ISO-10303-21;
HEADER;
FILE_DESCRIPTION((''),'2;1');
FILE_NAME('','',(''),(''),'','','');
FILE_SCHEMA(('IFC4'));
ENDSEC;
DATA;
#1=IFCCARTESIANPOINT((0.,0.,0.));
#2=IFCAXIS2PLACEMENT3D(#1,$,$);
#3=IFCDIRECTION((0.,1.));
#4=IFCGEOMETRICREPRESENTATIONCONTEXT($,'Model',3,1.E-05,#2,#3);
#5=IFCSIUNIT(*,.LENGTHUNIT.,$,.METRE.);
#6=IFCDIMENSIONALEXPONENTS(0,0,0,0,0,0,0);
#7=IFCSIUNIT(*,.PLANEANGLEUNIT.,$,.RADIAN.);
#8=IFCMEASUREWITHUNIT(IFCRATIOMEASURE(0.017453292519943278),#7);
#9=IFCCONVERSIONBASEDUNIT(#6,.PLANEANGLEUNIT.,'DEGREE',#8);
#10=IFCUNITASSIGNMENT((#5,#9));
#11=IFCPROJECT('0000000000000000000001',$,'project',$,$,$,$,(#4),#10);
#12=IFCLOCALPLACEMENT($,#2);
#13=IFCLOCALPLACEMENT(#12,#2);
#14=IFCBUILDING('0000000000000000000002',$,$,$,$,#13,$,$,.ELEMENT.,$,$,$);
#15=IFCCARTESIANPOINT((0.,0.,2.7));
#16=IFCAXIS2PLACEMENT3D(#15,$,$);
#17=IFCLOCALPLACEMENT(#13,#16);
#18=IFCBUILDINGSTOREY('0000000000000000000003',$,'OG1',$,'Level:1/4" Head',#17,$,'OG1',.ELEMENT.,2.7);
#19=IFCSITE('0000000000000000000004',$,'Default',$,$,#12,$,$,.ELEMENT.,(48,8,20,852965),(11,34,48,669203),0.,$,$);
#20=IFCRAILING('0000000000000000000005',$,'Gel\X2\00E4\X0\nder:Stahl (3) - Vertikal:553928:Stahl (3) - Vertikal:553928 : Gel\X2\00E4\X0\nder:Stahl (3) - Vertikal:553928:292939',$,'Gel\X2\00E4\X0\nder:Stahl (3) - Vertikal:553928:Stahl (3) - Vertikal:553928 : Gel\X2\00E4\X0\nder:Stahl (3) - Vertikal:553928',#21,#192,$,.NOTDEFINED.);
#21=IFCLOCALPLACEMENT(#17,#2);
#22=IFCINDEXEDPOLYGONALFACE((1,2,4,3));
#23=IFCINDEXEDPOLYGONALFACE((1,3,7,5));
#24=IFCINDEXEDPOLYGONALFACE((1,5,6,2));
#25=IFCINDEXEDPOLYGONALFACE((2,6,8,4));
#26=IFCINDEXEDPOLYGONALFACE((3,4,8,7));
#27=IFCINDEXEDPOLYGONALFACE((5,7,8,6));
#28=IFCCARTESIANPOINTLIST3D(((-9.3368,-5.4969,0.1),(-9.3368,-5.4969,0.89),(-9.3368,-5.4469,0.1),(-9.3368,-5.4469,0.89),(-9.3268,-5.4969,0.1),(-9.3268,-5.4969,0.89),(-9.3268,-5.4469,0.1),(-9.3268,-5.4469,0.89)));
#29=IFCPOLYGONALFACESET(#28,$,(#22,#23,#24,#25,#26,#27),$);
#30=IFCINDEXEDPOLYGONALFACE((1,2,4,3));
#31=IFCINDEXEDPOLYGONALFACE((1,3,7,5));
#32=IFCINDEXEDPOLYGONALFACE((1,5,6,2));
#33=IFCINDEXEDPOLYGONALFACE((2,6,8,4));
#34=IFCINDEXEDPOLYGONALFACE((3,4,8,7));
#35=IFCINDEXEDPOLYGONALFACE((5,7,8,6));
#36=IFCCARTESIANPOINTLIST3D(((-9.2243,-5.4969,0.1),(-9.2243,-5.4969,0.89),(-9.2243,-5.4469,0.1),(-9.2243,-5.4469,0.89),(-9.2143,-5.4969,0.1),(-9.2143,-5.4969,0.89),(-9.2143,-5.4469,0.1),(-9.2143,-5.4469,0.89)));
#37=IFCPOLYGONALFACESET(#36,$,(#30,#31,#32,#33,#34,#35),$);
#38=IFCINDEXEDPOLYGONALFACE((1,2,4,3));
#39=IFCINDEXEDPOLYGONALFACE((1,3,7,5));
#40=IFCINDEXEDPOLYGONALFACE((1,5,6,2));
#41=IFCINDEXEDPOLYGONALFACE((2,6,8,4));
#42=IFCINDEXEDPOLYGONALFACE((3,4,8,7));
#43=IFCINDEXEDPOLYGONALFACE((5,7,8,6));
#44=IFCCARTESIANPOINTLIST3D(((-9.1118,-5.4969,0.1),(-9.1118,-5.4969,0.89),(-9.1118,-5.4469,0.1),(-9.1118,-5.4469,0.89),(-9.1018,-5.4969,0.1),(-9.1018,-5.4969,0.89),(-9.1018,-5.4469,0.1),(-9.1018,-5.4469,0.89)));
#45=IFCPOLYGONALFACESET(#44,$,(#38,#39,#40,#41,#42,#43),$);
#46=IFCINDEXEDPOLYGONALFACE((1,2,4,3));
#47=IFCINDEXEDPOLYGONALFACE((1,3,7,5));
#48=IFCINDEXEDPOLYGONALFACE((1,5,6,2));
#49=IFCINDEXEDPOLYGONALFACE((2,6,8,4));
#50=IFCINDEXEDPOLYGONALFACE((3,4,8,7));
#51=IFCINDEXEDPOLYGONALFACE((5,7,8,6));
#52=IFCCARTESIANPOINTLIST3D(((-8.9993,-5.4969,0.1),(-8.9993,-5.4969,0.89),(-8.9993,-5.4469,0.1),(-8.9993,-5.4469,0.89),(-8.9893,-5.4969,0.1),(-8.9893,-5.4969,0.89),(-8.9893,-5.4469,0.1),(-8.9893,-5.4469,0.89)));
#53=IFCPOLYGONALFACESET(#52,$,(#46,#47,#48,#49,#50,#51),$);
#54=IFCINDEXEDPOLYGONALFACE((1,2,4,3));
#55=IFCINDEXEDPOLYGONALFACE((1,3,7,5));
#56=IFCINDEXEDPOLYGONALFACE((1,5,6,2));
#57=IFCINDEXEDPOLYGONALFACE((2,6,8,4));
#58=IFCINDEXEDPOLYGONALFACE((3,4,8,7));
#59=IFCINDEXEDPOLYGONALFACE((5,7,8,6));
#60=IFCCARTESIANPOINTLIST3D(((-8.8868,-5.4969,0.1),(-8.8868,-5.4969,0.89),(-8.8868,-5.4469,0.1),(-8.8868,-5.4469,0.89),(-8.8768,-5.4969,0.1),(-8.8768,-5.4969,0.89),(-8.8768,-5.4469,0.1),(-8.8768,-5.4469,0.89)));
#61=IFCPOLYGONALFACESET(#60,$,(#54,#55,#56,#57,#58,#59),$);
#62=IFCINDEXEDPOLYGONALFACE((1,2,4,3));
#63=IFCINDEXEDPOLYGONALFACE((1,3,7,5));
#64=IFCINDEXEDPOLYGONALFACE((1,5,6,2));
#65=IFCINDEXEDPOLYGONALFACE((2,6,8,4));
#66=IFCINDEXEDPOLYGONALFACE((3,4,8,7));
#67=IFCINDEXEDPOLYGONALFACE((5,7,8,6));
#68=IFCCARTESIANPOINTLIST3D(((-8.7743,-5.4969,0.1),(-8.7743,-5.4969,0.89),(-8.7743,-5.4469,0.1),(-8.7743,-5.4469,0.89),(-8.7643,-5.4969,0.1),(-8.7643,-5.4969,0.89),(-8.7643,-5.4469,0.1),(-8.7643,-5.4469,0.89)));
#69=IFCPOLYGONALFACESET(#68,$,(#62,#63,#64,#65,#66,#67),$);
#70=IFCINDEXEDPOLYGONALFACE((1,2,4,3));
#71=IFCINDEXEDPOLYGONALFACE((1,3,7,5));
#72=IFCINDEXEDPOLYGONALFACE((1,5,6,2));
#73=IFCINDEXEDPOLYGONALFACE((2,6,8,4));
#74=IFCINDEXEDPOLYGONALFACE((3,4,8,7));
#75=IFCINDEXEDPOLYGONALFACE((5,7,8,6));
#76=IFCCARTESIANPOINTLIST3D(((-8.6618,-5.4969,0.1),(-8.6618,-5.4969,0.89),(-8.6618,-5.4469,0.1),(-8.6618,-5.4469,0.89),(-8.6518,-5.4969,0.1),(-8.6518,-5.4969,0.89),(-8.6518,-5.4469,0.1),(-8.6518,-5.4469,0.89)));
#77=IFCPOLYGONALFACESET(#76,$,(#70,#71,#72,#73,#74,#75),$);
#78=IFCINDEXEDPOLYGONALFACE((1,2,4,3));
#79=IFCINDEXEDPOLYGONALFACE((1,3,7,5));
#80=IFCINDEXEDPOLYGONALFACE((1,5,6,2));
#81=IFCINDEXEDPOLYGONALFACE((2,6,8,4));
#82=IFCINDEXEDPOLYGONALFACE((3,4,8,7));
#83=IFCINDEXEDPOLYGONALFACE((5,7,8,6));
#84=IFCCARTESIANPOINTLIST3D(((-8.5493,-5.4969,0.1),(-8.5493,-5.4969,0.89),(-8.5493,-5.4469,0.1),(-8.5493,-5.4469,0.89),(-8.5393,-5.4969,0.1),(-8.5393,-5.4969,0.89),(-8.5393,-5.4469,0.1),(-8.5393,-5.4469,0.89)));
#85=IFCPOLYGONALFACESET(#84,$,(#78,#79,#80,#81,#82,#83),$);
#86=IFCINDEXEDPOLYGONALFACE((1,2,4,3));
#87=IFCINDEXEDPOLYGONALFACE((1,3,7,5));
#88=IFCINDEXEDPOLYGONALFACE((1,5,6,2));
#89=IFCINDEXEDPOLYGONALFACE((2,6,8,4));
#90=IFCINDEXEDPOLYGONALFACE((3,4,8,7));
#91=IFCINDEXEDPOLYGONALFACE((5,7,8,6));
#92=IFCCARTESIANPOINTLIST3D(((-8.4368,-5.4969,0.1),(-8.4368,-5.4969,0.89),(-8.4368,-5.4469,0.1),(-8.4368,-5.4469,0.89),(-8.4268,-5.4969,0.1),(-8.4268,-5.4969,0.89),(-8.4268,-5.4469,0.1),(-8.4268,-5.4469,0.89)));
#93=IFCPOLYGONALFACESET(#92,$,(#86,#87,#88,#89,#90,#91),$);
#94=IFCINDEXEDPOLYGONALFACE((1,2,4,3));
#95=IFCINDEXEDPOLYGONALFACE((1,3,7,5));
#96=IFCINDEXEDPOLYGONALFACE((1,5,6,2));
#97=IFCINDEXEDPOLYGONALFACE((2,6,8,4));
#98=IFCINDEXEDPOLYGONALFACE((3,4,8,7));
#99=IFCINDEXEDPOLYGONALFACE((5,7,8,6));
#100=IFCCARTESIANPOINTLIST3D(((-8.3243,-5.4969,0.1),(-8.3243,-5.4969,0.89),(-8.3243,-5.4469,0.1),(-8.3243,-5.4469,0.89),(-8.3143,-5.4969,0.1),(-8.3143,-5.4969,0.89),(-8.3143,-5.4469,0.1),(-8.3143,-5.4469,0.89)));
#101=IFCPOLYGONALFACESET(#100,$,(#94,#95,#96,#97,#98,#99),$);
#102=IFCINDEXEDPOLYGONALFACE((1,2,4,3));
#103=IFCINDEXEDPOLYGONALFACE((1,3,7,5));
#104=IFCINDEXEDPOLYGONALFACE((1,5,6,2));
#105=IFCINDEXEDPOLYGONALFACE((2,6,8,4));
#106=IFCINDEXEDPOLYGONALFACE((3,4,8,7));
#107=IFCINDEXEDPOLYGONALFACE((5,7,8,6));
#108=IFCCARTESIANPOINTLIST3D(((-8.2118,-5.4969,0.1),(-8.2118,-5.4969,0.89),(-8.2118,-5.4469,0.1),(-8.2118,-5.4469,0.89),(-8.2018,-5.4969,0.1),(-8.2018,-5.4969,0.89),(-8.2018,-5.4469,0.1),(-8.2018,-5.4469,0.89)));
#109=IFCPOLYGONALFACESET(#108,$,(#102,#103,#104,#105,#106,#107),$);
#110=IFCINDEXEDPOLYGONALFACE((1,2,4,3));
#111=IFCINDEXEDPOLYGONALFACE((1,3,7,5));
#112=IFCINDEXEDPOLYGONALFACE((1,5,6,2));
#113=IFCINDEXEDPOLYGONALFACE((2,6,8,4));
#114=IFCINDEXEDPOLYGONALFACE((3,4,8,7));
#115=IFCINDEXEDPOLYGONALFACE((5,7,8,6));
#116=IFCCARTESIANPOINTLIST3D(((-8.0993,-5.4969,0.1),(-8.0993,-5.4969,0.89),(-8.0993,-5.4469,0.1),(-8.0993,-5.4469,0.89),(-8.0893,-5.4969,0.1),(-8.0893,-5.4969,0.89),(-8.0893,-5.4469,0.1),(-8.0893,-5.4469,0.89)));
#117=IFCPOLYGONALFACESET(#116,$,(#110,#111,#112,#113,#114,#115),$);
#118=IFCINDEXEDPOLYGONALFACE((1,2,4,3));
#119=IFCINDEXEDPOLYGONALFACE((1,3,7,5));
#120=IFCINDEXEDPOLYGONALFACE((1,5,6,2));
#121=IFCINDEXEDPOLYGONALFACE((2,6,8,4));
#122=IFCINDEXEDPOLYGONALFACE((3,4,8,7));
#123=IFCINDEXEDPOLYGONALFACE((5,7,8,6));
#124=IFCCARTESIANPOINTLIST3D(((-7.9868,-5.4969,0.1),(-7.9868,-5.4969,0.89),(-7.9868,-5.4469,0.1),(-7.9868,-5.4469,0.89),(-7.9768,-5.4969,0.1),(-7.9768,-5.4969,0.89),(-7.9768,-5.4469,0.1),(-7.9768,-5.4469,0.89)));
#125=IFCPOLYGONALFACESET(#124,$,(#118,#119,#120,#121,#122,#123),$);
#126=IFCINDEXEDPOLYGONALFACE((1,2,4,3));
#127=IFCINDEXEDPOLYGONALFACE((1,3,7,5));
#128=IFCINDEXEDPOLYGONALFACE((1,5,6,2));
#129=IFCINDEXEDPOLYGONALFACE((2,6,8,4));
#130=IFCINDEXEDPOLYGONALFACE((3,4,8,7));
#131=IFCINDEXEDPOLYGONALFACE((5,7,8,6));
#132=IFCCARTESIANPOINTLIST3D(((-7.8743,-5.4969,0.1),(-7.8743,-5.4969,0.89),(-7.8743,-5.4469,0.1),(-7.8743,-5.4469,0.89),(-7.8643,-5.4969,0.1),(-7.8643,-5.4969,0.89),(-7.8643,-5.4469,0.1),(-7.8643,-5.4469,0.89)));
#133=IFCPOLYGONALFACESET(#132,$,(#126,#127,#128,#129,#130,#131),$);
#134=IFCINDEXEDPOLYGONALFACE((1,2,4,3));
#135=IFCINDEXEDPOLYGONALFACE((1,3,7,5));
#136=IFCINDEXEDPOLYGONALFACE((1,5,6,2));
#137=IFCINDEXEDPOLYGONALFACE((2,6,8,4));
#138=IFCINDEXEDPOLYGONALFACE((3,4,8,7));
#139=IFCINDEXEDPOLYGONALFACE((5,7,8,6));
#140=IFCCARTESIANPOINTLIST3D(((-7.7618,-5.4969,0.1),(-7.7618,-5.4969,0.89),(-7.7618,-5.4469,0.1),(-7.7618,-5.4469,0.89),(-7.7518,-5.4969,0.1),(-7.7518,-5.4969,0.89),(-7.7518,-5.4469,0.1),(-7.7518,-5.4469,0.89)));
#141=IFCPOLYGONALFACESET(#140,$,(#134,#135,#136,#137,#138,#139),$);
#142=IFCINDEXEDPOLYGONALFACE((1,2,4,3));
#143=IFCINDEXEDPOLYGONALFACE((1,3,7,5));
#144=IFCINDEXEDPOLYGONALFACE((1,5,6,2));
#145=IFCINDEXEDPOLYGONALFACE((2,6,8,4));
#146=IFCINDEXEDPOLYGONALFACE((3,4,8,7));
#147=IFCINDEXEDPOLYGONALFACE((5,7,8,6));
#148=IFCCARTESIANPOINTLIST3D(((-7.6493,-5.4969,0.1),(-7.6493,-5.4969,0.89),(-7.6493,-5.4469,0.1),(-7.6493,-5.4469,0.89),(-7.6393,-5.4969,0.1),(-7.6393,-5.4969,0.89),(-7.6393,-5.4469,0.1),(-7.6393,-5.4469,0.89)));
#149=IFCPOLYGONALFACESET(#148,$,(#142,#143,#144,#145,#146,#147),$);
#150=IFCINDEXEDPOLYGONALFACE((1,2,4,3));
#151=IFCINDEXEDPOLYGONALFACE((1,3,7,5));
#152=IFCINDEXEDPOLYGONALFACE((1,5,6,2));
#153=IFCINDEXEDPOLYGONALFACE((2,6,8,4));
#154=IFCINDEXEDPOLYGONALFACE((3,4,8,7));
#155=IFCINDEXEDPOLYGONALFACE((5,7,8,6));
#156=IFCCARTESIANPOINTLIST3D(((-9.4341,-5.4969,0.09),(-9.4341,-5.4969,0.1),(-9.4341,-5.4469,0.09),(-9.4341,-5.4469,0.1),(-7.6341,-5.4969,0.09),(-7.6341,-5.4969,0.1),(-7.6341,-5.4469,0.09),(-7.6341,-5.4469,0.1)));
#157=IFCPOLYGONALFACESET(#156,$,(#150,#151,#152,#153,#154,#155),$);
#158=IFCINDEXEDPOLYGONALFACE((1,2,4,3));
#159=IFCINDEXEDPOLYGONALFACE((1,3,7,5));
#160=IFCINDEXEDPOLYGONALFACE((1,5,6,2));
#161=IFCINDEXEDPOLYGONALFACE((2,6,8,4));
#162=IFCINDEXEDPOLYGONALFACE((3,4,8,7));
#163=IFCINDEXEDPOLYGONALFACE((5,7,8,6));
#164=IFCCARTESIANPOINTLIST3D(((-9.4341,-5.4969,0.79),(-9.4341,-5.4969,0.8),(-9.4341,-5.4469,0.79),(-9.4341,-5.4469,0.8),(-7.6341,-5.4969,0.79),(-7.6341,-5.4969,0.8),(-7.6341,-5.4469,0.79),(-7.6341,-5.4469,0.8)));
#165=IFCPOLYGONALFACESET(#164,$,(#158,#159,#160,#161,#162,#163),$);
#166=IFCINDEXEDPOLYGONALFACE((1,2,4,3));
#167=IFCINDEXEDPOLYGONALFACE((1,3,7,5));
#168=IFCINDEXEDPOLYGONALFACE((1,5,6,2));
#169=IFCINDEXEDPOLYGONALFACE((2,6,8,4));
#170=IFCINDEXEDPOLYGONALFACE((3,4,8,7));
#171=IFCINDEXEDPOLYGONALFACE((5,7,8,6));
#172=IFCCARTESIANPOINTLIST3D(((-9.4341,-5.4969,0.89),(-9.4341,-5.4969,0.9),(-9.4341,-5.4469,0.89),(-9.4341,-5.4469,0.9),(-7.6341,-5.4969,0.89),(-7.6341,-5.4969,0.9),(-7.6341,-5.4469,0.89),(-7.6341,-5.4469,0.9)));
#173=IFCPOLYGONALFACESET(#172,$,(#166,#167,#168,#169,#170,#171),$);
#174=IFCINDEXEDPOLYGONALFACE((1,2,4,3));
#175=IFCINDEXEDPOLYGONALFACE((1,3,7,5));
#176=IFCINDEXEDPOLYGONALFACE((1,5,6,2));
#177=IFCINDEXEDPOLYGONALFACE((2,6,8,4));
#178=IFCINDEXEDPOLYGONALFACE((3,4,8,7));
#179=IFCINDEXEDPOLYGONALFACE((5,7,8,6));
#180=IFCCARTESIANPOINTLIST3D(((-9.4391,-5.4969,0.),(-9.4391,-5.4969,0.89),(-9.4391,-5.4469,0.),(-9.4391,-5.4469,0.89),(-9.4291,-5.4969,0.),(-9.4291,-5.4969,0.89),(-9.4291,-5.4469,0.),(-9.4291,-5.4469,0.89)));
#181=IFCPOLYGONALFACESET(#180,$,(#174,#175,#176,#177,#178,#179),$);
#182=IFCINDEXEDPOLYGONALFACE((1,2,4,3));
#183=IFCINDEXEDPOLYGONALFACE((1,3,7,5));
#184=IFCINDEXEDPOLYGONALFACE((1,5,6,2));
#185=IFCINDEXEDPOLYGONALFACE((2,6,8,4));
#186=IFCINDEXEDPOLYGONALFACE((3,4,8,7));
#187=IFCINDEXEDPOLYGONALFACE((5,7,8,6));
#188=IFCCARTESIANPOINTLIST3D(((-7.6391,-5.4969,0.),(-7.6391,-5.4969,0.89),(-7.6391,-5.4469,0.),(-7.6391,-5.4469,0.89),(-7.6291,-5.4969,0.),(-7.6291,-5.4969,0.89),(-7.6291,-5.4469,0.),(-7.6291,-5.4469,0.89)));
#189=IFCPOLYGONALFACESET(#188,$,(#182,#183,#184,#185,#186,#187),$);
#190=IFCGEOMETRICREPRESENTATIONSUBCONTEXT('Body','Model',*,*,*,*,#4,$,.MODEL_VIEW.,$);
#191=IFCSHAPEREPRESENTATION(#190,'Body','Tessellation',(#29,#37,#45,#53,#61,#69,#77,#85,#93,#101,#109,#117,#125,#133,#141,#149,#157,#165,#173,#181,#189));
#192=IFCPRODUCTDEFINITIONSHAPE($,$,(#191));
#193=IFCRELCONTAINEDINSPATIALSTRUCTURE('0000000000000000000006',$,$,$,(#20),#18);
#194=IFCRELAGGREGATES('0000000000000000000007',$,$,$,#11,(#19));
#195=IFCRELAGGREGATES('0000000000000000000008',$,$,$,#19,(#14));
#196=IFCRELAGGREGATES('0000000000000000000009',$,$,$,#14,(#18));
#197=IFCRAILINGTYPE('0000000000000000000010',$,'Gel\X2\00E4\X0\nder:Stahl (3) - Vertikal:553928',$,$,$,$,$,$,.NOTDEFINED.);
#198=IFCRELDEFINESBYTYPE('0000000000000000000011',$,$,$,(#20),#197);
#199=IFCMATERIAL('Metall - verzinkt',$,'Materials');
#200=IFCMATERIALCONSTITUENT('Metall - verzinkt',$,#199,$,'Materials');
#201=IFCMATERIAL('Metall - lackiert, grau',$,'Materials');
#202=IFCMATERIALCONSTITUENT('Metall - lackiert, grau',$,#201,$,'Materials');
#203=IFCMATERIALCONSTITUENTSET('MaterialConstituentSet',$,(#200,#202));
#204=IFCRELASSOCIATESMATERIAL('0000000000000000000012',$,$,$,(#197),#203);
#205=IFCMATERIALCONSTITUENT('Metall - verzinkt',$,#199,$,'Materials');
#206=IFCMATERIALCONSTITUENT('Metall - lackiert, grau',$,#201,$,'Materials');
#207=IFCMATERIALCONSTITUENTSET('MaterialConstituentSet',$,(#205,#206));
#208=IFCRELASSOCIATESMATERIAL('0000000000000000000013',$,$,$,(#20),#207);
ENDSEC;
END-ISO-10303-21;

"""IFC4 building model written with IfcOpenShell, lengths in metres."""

from ifc_helpers import new_model, entity, si_unit, converted_unit, direction, frame, origin, place, context, subcontext, project, spatial, indexed_curve, outline, extrude, source, transform, mapped, material, constituent, constituent_set, type_object, type_shapes, element, save


model = new_model("IFC4")

# Units and contexts
model_context = context("Model", 3, precision=1e-05, world=origin(), true_north=direction((0.0, 1.0)))
body_context = subcontext(model_context, "Body", "Model", "MODEL_VIEW")
ifc_project = project(units=[si_unit("LENGTHUNIT", "METRE"), converted_unit("PLANEANGLEUNIT", "DEGREE", entity("IfcRatioMeasure", 0.017453292519943278), si_unit("PLANEANGLEUNIT", "RADIAN"), dimensions=[0, 0, 0, 0, 0, 0, 0])], contexts=[model_context])

# Site, building, storey
site_placement = place(None, origin())
site = spatial("IfcSite", under=ifc_project, at=site_placement, Name="Default", CompositionType="ELEMENT", RefLatitude=(48, 8, 20, 852965), RefLongitude=(11, 34, 48, 669203), RefElevation=0.0)
building_placement = place(site_placement, origin())
building = spatial("IfcBuilding", under=site, at=building_placement, CompositionType="ELEMENT")
storey_placement = place(building_placement, frame((0.0, 0.0, 2.7)))
storey = spatial("IfcBuildingStorey", under=building, at=storey_placement, Name="OG1", ObjectType="Level:1/4\" Head", LongName="OG1", CompositionType="ELEMENT", Elevation=2.7)

# Railing
ifc_material_1 = material(Name="Metall - lackiert, grau", Category="Materials")
ifc_material_2 = material(Name="Metall - verzinkt", Category="Materials")
ifc_constituent_1 = constituent(ifc_material_2, Name="Metall - verzinkt", Category="Materials")
ifc_constituent_2 = constituent(ifc_material_1, Name="Metall - lackiert, grau", Category="Materials")
ifc_constituent_set_1 = constituent_set(constituents=[ifc_constituent_1, ifc_constituent_2], Name="MaterialConstituentSet")
ifc_constituent_3 = constituent(ifc_material_2, Name="Metall - verzinkt", Category="Materials")
ifc_constituent_4 = constituent(ifc_material_1, Name="Metall - lackiert, grau", Category="Materials")
ifc_constituent_set_2 = constituent_set(constituents=[ifc_constituent_3, ifc_constituent_4], Name="MaterialConstituentSet")
railing_type_1 = type_object("IfcRailingType", Name="Geländer:Stahl (3) - Vertikal:553928", PredefinedType="NOTDEFINED", material=ifc_constituent_set_2)
shared_shape_1 = source(origin(), body_context, "Body", "SweptSolid", [
    extrude(outline(indexed_curve([(-0.025, -0.005), (0.025, -0.005), (0.025, 0.005), (-0.025, 0.005), (-0.025, -0.005)], self_intersect=False)), frame((-9.3318, -5.4719, 2.8), z_axis=(0.0, 0.0, 1.0), x_axis=(0.0, 1.0, 0.0)), (0.0, 0.0, 1.0), 0.79),
    extrude(outline(indexed_curve([(-0.025, -0.005), (0.025, -0.005), (0.025, 0.005), (-0.025, 0.005), (-0.025, -0.005)], self_intersect=False)), frame((-9.2193, -5.4719, 2.8), z_axis=(0.0, 0.0, 1.0), x_axis=(0.0, 1.0, 0.0)), (0.0, 0.0, 1.0), 0.79),
    extrude(outline(indexed_curve([(-0.025, -0.005), (0.025, -0.005), (0.025, 0.005), (-0.025, 0.005), (-0.025, -0.005)], self_intersect=False)), frame((-9.1068, -5.4719, 2.8), z_axis=(0.0, 0.0, 1.0), x_axis=(0.0, 1.0, 0.0)), (0.0, 0.0, 1.0), 0.79),
    extrude(outline(indexed_curve([(-0.025, -0.005), (0.025, -0.005), (0.025, 0.005), (-0.025, 0.005), (-0.025, -0.005)], self_intersect=False)), frame((-8.9943, -5.4719, 2.8), z_axis=(0.0, 0.0, 1.0), x_axis=(0.0, 1.0, 0.0)), (0.0, 0.0, 1.0), 0.79),
    extrude(outline(indexed_curve([(-0.025, -0.005), (0.025, -0.005), (0.025, 0.005), (-0.025, 0.005), (-0.025, -0.005)], self_intersect=False)), frame((-8.8818, -5.4719, 2.8), z_axis=(0.0, 0.0, 1.0), x_axis=(0.0, 1.0, 0.0)), (0.0, 0.0, 1.0), 0.79),
    extrude(outline(indexed_curve([(-0.025, -0.005), (0.025, -0.005), (0.025, 0.005), (-0.025, 0.005), (-0.025, -0.005)], self_intersect=False)), frame((-8.7693, -5.4719, 2.8), z_axis=(0.0, 0.0, 1.0), x_axis=(0.0, 1.0, 0.0)), (0.0, 0.0, 1.0), 0.79),
    extrude(outline(indexed_curve([(-0.025, -0.005), (0.025, -0.005), (0.025, 0.005), (-0.025, 0.005), (-0.025, -0.005)], self_intersect=False)), frame((-8.6568, -5.4719, 2.8), z_axis=(0.0, 0.0, 1.0), x_axis=(0.0, 1.0, 0.0)), (0.0, 0.0, 1.0), 0.79),
    extrude(outline(indexed_curve([(-0.025, -0.005), (0.025, -0.005), (0.025, 0.005), (-0.025, 0.005), (-0.025, -0.005)], self_intersect=False)), frame((-8.5443, -5.4719, 2.8), z_axis=(0.0, 0.0, 1.0), x_axis=(0.0, 1.0, 0.0)), (0.0, 0.0, 1.0), 0.79),
    extrude(outline(indexed_curve([(-0.025, -0.005), (0.025, -0.005), (0.025, 0.005), (-0.025, 0.005), (-0.025, -0.005)], self_intersect=False)), frame((-8.4318, -5.4719, 2.8), z_axis=(0.0, 0.0, 1.0), x_axis=(0.0, 1.0, 0.0)), (0.0, 0.0, 1.0), 0.79),
    extrude(outline(indexed_curve([(-0.025, -0.005), (0.025, -0.005), (0.025, 0.005), (-0.025, 0.005), (-0.025, -0.005)], self_intersect=False)), frame((-8.3193, -5.4719, 2.8), z_axis=(0.0, 0.0, 1.0), x_axis=(0.0, 1.0, 0.0)), (0.0, 0.0, 1.0), 0.79),
    extrude(outline(indexed_curve([(-0.025, -0.005), (0.025, -0.005), (0.025, 0.005), (-0.025, 0.005), (-0.025, -0.005)], self_intersect=False)), frame((-8.2068, -5.4719, 2.8), z_axis=(0.0, 0.0, 1.0), x_axis=(0.0, 1.0, 0.0)), (0.0, 0.0, 1.0), 0.79),
    extrude(outline(indexed_curve([(-0.025, -0.005), (0.025, -0.005), (0.025, 0.005), (-0.025, 0.005), (-0.025, -0.005)], self_intersect=False)), frame((-8.0943, -5.4719, 2.8), z_axis=(0.0, 0.0, 1.0), x_axis=(0.0, 1.0, 0.0)), (0.0, 0.0, 1.0), 0.79),
    extrude(outline(indexed_curve([(-0.025, -0.005), (0.025, -0.005), (0.025, 0.005), (-0.025, 0.005), (-0.025, -0.005)], self_intersect=False)), frame((-7.9818, -5.4719, 2.8), z_axis=(0.0, 0.0, 1.0), x_axis=(0.0, 1.0, 0.0)), (0.0, 0.0, 1.0), 0.79),
    extrude(outline(indexed_curve([(-0.025, -0.005), (0.025, -0.005), (0.025, 0.005), (-0.025, 0.005), (-0.025, -0.005)], self_intersect=False)), frame((-7.8693, -5.4719, 2.8), z_axis=(0.0, 0.0, 1.0), x_axis=(0.0, 1.0, 0.0)), (0.0, 0.0, 1.0), 0.79),
    extrude(outline(indexed_curve([(-0.025, -0.005), (0.025, -0.005), (0.025, 0.005), (-0.025, 0.005), (-0.025, -0.005)], self_intersect=False)), frame((-7.7568, -5.4719, 2.8), z_axis=(0.0, 0.0, 1.0), x_axis=(0.0, 1.0, 0.0)), (0.0, 0.0, 1.0), 0.79),
    extrude(outline(indexed_curve([(-0.025, -0.005), (0.025, -0.005), (0.025, 0.005), (-0.025, 0.005), (-0.025, -0.005)], self_intersect=False)), frame((-7.6443, -5.4719, 2.8), z_axis=(0.0, 0.0, 1.0), x_axis=(0.0, 1.0, 0.0)), (0.0, 0.0, 1.0), 0.79),
    extrude(outline(indexed_curve([(-0.025, -0.9), (0.025, -0.9), (0.025, 0.9), (-0.025, 0.9), (-0.025, -0.9)], self_intersect=False)), frame((-8.5341, -5.4719, 2.79), z_axis=(0.0, 0.0, 1.0), x_axis=(0.0, 1.0, 0.0)), (0.0, 0.0, 1.0), 0.01),
    extrude(outline(indexed_curve([(-0.025, -0.9), (0.025, -0.9), (0.025, 0.9), (-0.025, 0.9), (-0.025, -0.9)], self_intersect=False)), frame((-8.5341, -5.4719, 3.49), z_axis=(0.0, 0.0, 1.0), x_axis=(0.0, 1.0, 0.0)), (0.0, 0.0, 1.0), 0.01),
    extrude(outline(indexed_curve([(-0.025, -0.9), (0.025, -0.9), (0.025, 0.9), (-0.025, 0.9), (-0.025, -0.9)], self_intersect=False)), frame((-8.5341, -5.4719, 3.59), z_axis=(0.0, 0.0, 1.0), x_axis=(0.0, 1.0, 0.0)), (0.0, 0.0, 1.0), 0.01),
    extrude(outline(indexed_curve([(-0.025, -0.005), (0.025, -0.005), (0.025, 0.005), (-0.025, 0.005), (-0.025, -0.005)], self_intersect=False)), frame((-9.4341, -5.4719, 2.7), z_axis=(0.0, 0.0, 1.0), x_axis=(0.0, 1.0, 0.0)), (0.0, 0.0, 1.0), 0.89),
    extrude(outline(indexed_curve([(-0.025, -0.005), (0.025, -0.005), (0.025, 0.005), (-0.025, 0.005), (-0.025, -0.005)], self_intersect=False)), frame((-7.6341, -5.4719, 2.7), z_axis=(0.0, 0.0, 1.0), x_axis=(0.0, 1.0, 0.0)), (0.0, 0.0, 1.0), 0.89),
])
type_shapes(railing_type_1, [shared_shape_1])
railing_1_placement = place(storey_placement, frame((0.0, 0.0, -2.7)))
element("IfcRailing", 1, at=railing_1_placement, inside=storey, type_object=railing_type_1, material=ifc_constituent_set_1, Name="Geländer:Stahl (3) - Vertikal:553928:Stahl (3) - Vertikal:553928 : Geländer:Stahl (3) - Vertikal:553928:292939", ObjectType="Geländer:Stahl (3) - Vertikal:553928:Stahl (3) - Vertikal:553928 : Geländer:Stahl (3) - Vertikal:553928", PredefinedType="NOTDEFINED", context=body_context, shape_type="MappedRepresentation", body=[
    mapped(shared_shape_1, transform((0.0, 0.0, 0.0), scale=1.0)),
])

save(model, "model.ifc")
